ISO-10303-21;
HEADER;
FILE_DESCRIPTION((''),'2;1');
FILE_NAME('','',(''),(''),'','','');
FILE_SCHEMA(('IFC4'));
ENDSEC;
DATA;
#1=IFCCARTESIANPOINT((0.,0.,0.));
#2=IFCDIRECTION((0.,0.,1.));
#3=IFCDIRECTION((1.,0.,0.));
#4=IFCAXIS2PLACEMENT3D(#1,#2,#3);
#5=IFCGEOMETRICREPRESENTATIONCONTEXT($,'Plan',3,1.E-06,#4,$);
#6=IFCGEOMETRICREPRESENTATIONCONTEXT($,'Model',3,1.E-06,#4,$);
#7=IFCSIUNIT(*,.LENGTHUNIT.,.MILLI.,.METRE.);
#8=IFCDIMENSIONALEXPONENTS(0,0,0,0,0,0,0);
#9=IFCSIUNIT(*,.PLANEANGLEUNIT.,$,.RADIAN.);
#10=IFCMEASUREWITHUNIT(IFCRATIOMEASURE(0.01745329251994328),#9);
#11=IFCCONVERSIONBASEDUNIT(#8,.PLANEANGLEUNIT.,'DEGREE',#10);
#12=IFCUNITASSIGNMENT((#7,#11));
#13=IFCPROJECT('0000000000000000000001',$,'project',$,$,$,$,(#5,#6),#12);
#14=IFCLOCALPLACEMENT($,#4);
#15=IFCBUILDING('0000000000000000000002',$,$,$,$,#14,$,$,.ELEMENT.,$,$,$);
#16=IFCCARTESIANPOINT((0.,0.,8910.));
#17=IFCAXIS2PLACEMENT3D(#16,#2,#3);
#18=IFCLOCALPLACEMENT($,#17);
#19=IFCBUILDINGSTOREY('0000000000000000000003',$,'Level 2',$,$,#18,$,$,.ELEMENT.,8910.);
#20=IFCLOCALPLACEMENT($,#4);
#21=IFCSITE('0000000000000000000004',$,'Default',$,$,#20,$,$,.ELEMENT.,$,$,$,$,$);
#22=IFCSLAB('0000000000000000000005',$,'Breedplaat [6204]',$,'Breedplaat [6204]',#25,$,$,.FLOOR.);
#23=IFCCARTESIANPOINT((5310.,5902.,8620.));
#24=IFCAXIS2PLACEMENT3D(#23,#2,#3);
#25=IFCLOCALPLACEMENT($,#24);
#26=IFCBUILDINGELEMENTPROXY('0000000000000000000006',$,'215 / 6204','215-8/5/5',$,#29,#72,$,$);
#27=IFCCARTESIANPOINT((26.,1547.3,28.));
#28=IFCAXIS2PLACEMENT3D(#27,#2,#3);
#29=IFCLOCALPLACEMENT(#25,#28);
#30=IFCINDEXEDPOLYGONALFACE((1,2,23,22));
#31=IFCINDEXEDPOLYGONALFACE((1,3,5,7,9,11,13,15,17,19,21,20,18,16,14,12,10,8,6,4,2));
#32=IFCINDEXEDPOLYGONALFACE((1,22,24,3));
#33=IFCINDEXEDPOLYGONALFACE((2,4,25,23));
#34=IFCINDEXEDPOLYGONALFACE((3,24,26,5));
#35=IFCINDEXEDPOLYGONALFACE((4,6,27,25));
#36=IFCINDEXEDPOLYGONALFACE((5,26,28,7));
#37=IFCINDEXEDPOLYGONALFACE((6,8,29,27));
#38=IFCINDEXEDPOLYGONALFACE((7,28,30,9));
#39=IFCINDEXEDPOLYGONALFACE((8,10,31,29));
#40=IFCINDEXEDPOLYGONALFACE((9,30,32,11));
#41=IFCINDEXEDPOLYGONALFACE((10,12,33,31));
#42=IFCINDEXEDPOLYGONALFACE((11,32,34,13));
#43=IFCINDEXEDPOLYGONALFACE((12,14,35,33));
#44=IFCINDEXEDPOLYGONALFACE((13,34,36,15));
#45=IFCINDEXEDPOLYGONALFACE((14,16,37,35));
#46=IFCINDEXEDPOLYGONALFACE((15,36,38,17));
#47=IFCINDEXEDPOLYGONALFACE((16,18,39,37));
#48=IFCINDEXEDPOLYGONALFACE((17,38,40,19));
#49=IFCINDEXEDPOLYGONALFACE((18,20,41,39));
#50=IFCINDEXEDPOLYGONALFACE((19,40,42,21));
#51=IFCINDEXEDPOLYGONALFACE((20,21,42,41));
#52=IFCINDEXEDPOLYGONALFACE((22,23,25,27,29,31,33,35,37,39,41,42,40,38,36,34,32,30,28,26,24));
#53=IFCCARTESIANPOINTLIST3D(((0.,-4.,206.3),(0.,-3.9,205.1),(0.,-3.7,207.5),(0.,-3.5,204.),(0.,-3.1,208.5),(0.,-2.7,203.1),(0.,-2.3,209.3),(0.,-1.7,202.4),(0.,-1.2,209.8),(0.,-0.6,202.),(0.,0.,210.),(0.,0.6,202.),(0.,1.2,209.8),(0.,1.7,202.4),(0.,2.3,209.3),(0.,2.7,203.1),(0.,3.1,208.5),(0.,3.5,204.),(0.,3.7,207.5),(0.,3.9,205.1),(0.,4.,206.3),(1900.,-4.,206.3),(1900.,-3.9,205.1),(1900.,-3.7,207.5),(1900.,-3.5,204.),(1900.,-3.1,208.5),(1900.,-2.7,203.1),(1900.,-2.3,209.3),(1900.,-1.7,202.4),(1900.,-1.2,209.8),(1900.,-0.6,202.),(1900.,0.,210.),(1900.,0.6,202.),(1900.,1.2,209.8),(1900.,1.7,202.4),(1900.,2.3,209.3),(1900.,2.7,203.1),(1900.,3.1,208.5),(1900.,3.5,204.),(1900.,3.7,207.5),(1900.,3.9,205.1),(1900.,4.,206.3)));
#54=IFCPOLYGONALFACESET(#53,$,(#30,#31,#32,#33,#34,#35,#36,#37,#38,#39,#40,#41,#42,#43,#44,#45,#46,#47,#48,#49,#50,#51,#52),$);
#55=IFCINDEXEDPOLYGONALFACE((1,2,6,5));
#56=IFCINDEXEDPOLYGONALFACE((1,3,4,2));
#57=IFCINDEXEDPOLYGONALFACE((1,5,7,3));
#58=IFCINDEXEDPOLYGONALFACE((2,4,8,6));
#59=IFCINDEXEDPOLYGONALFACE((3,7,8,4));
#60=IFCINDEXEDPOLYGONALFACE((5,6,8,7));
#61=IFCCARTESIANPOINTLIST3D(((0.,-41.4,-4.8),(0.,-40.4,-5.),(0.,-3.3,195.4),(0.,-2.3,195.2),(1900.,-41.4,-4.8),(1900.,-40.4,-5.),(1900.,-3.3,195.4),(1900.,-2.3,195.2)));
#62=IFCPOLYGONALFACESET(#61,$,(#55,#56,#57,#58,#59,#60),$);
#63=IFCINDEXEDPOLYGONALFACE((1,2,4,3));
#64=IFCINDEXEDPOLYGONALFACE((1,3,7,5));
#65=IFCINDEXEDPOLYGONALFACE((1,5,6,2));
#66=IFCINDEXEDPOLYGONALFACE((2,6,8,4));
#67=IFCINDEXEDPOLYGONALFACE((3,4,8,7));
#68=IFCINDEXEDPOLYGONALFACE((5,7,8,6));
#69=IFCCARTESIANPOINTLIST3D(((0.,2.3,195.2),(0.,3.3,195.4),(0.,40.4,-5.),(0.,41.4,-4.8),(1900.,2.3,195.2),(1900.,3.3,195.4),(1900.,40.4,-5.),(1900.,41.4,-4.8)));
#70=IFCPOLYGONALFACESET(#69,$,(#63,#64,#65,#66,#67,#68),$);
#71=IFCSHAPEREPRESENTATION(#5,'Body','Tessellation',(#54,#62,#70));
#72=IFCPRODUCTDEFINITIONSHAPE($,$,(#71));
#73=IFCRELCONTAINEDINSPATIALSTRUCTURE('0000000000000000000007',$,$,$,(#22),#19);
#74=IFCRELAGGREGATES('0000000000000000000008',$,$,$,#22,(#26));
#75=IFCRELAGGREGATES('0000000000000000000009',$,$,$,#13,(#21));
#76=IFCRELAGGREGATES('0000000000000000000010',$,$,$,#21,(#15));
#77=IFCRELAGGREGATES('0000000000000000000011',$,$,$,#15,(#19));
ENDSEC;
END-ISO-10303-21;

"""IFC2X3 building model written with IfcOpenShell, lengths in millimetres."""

from ifc_helpers import new_model, entity, si_unit, converted_unit, frame, origin_with_axes, origin_2d_with_axis, place, context, project, spatial, rectangle, circle, extrude, element, aggregate, save


model = new_model("IFC2X3")

# Units and contexts
plan_context = context("Plan", 3, precision=1e-06, world=origin_with_axes())
model_context = context("Model", 3, precision=1e-06, world=origin_with_axes())
ifc_project = project(units=[si_unit("LENGTHUNIT", "METRE", prefix="MILLI"), converted_unit("PLANEANGLEUNIT", "DEGREE", entity("IfcRatioMeasure", 0.01745329251994328), si_unit("PLANEANGLEUNIT", "RADIAN"), dimensions=[0, 0, 0, 0, 0, 0, 0])], contexts=[plan_context, model_context])

# Site, building, storey
site_placement = place(None, origin_with_axes())
site = spatial("IfcSite", under=ifc_project, at=site_placement, Name="Default", CompositionType="ELEMENT")
building_placement = place(None, origin_with_axes())
building = spatial("IfcBuilding", under=site, at=building_placement, CompositionType="ELEMENT")
storey_placement = place(None, frame((0.0, 0.0, 8910.0), z_axis=(0.0, 0.0, 1.0), x_axis=(1.0, 0.0, 0.0)))
storey = spatial("IfcBuildingStorey", under=building, at=storey_placement, Name="Level 2", CompositionType="ELEMENT", Elevation=8910.0)

# Slab, building element proxy
slab_1_placement = place(None, frame((5310.0, 5902.0, 8620.0), z_axis=(0.0, 0.0, 1.0), x_axis=(1.0, 0.0, 0.0)))
slab_1 = element("IfcSlab", 1, at=slab_1_placement, inside=storey, Name="Breedplaat [6204]", ObjectType="Breedplaat [6204]", PredefinedType="FLOOR")
proxy_1_placement = place(slab_1_placement, frame((26.0, 1547.3, 28.0), z_axis=(0.0, 0.0, 1.0), x_axis=(1.0, 0.0, 0.0)))
proxy_1 = element("IfcBuildingElementProxy", 2, at=proxy_1_placement, Name="215 / 6204", Description="215-8/5/5", context=plan_context, shape_type="SweptSolid", body=[
    extrude(circle(Radius=4.0, at=origin_2d_with_axis()), frame((0.0, 0.0, 206.0), z_axis=(1.0, 0.0, 0.0), x_axis=(0.0, 0.0, 1.0)), (0.0, 0.0, 1.0), 1900.0),
    extrude(rectangle(XDim=203.8, YDim=1.0, at=origin_2d_with_axis()), frame((0.0, -21.9, 95.2), z_axis=(1.0, 0.0, 0.0), x_axis=(0.0, 0.187112, 0.982339)), (0.0, 0.0, 1.0), 1900.0),
    extrude(rectangle(XDim=203.8, YDim=1.0, at=origin_2d_with_axis()), frame((0.0, 21.9, 95.2), z_axis=(1.0, 0.0, 0.0), x_axis=(0.0, -0.187112, 0.982339)), (0.0, 0.0, 1.0), 1900.0),
])
aggregate(slab_1, [proxy_1])

save(model, "model.ifc")
